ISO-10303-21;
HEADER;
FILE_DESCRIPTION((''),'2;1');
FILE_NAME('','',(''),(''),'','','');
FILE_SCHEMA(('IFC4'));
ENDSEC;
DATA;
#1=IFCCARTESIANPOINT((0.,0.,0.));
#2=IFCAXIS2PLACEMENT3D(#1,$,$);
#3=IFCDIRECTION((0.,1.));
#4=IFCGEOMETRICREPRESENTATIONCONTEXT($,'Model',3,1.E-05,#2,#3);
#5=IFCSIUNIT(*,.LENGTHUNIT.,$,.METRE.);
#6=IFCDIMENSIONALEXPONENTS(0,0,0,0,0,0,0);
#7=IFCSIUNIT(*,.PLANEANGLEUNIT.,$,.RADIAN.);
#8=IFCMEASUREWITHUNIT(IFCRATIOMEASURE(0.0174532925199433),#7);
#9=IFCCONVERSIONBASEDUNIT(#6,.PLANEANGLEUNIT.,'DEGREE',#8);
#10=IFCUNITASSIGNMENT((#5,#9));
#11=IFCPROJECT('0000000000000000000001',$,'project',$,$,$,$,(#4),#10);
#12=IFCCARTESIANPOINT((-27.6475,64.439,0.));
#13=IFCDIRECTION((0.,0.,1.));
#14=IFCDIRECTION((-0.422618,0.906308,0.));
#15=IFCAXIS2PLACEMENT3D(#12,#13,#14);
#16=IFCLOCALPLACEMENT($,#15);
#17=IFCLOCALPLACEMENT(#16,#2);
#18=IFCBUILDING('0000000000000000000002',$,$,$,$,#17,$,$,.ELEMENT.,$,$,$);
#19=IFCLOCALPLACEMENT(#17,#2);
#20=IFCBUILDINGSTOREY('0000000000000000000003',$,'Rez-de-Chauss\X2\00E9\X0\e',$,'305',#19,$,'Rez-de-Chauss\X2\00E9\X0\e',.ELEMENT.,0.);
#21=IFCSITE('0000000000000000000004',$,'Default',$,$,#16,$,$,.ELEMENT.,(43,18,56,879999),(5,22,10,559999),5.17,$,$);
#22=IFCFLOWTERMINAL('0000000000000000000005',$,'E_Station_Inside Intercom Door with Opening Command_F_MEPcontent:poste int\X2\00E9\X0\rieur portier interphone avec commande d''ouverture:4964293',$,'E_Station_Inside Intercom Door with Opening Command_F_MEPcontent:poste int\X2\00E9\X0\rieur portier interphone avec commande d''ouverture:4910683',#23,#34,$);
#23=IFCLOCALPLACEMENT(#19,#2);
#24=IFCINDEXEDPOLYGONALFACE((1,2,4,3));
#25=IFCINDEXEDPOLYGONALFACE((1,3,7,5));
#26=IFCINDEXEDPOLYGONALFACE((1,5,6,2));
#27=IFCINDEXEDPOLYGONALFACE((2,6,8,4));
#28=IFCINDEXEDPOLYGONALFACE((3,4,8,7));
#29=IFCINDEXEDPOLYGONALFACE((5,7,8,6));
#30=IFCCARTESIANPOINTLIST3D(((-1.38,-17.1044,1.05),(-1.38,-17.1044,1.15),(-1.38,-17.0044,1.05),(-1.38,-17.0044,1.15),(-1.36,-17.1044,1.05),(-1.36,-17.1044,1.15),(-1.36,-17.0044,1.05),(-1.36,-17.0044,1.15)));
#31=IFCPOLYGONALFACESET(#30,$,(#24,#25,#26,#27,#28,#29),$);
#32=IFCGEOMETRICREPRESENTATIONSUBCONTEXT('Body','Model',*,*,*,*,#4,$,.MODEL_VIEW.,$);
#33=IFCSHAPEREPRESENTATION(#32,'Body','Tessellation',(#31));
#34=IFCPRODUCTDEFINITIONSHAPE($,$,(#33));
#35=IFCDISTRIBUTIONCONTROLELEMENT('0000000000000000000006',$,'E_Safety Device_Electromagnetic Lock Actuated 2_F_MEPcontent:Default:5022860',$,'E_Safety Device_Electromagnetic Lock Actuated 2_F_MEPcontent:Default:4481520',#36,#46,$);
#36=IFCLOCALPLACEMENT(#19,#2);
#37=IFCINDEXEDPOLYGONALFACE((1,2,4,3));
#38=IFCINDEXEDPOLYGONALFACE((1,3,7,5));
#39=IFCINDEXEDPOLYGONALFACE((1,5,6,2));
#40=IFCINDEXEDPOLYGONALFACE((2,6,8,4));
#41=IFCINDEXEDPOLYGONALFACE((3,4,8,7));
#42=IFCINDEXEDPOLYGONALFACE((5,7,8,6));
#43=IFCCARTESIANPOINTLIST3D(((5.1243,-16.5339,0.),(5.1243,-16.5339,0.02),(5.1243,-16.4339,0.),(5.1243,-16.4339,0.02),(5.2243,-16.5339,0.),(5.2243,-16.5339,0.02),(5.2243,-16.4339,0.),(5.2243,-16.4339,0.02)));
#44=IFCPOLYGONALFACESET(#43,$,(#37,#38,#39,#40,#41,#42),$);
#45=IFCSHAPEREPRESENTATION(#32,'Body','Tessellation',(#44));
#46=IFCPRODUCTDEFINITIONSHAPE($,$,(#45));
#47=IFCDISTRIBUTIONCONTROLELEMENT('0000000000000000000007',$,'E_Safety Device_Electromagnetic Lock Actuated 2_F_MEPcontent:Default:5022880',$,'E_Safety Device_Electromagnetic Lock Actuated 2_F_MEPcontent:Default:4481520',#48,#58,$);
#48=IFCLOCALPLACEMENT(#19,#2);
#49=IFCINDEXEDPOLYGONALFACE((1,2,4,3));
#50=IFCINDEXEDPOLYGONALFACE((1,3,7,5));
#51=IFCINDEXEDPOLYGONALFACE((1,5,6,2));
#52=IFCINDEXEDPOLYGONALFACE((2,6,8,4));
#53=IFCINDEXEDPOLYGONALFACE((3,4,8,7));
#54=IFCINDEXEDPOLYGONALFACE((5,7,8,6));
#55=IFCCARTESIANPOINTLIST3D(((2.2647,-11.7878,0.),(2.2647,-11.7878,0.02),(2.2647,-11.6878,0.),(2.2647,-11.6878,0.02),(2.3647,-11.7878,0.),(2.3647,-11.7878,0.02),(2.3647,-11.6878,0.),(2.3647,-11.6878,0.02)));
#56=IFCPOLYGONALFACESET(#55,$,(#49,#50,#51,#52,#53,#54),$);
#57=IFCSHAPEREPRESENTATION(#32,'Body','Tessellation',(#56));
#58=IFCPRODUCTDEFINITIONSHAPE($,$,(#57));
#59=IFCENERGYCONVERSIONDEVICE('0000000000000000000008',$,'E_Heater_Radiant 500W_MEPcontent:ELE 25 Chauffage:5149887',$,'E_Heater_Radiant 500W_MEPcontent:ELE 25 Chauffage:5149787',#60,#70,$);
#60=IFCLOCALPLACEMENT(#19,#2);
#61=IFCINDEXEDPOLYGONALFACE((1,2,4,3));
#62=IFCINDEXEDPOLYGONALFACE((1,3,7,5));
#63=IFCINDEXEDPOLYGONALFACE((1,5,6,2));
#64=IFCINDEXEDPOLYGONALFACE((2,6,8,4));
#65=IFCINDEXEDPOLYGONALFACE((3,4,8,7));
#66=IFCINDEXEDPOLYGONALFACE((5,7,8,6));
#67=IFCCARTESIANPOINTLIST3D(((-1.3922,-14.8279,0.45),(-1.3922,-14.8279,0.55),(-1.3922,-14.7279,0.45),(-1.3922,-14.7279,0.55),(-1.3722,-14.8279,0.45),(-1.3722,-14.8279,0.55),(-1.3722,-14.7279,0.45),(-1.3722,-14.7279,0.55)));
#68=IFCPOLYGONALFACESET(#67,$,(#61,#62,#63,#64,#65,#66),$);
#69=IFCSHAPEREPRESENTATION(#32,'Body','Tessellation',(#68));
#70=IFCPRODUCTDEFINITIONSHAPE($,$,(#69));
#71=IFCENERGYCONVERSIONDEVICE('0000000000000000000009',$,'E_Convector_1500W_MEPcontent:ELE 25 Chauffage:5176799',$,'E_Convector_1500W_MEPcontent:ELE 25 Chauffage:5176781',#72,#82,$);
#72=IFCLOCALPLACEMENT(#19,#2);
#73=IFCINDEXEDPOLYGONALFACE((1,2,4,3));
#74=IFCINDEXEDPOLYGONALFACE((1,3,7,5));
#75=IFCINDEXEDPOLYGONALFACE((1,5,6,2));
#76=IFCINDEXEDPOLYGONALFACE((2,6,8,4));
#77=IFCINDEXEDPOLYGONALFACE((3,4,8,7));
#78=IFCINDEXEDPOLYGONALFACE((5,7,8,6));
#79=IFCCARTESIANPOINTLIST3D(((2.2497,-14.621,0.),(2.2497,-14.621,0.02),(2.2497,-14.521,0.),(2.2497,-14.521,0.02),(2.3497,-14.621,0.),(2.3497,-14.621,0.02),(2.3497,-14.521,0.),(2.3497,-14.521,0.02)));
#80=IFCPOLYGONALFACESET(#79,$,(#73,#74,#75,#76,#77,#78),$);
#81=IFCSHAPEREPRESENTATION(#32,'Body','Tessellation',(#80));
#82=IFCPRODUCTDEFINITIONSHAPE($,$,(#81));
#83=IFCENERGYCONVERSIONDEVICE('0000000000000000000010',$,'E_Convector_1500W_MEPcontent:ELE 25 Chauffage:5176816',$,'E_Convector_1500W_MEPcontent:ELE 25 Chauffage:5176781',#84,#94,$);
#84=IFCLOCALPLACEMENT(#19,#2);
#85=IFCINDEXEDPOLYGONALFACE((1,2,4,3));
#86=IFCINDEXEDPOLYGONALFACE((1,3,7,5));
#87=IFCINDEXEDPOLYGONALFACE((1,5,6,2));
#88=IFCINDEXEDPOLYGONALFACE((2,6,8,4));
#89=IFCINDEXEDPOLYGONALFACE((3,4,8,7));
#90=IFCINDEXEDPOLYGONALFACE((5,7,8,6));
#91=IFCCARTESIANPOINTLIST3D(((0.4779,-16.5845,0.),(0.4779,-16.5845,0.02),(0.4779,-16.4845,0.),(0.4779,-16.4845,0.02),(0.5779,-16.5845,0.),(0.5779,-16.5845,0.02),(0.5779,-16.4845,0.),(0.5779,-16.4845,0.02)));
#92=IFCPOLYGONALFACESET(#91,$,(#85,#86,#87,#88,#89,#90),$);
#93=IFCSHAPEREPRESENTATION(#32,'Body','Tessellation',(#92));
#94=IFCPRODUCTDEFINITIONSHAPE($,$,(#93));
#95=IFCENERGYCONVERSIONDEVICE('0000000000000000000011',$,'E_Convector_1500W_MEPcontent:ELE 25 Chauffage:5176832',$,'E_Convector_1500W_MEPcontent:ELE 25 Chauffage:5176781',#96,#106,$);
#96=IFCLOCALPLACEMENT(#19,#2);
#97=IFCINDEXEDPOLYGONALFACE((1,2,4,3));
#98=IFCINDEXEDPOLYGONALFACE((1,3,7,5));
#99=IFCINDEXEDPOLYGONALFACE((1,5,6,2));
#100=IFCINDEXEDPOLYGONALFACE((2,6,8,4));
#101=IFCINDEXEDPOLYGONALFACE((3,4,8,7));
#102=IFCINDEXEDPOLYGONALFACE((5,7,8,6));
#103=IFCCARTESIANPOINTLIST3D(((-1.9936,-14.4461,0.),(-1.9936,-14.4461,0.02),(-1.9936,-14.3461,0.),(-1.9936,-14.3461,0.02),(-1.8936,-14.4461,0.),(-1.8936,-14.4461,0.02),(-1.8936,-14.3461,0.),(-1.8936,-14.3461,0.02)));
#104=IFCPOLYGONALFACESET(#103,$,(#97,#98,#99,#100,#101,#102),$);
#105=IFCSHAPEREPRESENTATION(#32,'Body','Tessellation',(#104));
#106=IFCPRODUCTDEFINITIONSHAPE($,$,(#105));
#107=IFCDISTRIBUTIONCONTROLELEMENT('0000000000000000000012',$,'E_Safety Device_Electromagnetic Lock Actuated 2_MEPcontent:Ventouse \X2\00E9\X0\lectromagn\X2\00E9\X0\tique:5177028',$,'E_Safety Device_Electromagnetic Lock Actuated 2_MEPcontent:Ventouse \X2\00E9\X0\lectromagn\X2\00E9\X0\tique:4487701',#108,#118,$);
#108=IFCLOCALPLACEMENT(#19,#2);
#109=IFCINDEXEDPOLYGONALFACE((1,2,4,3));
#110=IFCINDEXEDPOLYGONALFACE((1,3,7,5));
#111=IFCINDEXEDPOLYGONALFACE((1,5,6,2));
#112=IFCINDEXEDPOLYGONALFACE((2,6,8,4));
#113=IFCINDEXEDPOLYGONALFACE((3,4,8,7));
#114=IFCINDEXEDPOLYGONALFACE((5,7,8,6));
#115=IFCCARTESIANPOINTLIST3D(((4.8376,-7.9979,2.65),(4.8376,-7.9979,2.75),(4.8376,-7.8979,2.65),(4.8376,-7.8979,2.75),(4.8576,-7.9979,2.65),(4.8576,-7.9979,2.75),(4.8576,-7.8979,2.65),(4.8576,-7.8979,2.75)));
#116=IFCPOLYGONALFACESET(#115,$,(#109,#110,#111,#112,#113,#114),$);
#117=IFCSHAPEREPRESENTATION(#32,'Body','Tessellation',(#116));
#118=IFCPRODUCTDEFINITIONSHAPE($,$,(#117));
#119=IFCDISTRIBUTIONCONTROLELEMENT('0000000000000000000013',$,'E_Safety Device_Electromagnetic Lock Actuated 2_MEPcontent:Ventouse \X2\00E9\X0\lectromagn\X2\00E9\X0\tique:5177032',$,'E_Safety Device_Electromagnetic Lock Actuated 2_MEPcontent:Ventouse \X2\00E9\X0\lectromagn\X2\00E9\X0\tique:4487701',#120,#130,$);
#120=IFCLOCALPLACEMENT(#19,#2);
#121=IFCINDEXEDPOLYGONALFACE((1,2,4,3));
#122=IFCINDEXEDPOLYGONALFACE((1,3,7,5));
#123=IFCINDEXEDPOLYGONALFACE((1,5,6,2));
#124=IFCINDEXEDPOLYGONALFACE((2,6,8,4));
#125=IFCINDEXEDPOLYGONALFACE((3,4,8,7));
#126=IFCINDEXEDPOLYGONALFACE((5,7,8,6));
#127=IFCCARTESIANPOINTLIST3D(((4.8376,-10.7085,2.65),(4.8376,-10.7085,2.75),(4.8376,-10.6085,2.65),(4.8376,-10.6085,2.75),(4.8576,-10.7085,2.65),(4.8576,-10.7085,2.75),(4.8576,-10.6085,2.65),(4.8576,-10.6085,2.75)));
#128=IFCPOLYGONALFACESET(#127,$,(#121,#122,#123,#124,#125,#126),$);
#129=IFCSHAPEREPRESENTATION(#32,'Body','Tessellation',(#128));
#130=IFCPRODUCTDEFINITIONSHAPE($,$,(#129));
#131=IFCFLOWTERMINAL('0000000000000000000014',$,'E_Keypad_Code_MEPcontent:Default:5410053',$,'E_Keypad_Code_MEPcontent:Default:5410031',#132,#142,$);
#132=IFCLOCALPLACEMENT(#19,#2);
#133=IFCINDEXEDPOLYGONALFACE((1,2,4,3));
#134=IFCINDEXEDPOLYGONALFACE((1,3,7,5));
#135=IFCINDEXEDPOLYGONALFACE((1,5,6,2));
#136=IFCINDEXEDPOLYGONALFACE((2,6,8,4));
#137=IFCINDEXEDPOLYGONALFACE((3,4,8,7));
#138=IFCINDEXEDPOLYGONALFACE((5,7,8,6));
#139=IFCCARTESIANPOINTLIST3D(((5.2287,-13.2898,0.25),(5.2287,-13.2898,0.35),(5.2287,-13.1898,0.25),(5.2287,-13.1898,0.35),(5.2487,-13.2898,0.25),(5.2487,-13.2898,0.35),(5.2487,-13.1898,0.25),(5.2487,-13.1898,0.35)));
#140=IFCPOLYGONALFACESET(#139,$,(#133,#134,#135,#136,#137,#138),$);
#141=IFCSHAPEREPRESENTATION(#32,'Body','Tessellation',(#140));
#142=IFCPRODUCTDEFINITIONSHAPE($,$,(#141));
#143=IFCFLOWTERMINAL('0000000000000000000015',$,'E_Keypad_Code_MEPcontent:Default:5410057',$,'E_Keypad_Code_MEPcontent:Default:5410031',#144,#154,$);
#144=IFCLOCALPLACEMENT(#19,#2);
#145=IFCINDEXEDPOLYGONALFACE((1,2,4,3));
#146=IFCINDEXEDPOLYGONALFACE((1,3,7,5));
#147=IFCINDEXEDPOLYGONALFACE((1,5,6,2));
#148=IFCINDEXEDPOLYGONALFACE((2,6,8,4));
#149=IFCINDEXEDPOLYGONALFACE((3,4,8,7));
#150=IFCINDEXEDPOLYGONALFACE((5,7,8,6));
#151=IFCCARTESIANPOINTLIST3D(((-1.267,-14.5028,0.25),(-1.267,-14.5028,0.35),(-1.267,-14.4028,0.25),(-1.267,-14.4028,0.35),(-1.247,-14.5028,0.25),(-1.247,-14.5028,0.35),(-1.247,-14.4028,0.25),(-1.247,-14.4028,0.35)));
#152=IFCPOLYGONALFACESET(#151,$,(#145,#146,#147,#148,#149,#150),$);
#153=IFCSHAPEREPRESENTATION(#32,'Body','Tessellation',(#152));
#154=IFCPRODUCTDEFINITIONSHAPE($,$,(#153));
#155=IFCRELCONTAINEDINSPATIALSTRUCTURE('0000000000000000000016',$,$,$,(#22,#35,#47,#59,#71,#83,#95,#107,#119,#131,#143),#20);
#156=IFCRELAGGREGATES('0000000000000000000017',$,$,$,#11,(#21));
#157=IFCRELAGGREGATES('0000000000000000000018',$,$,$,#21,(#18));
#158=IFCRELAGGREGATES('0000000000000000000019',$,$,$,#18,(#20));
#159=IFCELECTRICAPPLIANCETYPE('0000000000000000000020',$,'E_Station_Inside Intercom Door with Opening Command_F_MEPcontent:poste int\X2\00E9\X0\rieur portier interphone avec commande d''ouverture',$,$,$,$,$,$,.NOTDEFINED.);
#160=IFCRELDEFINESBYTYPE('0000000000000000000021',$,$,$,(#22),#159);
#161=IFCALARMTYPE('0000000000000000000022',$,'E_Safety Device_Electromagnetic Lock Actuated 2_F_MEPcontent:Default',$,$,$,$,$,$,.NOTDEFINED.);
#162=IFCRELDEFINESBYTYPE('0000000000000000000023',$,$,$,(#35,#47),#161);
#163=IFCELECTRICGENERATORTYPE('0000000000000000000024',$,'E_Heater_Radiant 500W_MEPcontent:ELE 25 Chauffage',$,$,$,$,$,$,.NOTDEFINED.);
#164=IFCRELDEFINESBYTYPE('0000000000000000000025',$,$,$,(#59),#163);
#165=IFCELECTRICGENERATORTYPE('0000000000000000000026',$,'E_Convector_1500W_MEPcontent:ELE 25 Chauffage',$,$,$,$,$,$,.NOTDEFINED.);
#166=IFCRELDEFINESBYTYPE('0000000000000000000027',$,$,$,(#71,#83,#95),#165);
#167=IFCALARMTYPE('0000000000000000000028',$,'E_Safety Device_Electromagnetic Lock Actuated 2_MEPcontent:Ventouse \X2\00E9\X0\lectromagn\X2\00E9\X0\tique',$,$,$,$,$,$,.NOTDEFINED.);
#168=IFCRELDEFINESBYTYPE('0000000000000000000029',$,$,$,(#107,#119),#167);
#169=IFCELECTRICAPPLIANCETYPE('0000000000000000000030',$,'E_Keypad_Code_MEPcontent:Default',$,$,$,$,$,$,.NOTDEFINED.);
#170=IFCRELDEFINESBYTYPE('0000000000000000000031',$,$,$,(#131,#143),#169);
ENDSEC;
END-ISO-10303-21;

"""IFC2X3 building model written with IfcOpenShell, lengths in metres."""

from ifc_helpers import new_model, entity, si_unit, converted_unit, direction, frame, frame_2d, origin, origin_2d_with_axis, place, context, subcontext, project, spatial, rectangle, extrude, source, transform, mapped, type_object, type_shapes, element, save


model = new_model("IFC2X3")

# Units and contexts
model_context = context("Model", 3, precision=1e-05, world=origin(), true_north=direction((0.0, 1.0)))
body_context = subcontext(model_context, "Body", "Model", "MODEL_VIEW")
ifc_project = project(units=[si_unit("LENGTHUNIT", "METRE"), converted_unit("PLANEANGLEUNIT", "DEGREE", entity("IfcRatioMeasure", 0.0174532925199433), si_unit("PLANEANGLEUNIT", "RADIAN"), dimensions=[0, 0, 0, 0, 0, 0, 0])], contexts=[model_context])

# Site, building, storey
site_placement = place(None, frame((-27.6475, 64.439, 0.0), z_axis=(0.0, 0.0, 1.0), x_axis=(-0.422618, 0.906308, 0.0)))
site = spatial("IfcSite", under=ifc_project, at=site_placement, Name="Default", CompositionType="ELEMENT", RefLatitude=(43, 18, 56, 879999), RefLongitude=(5, 22, 10, 559999), RefElevation=5.17)
building_placement = place(site_placement, origin())
building = spatial("IfcBuilding", under=site, at=building_placement, CompositionType="ELEMENT")
storey_placement = place(building_placement, origin())
storey = spatial("IfcBuildingStorey", under=building, at=storey_placement, Name="Rez-de-Chaussée", ObjectType="305", LongName="Rez-de-Chaussée", CompositionType="ELEMENT", Elevation=0.0)

# Flow terminal
electric_appliance_type_1 = type_object("IfcElectricApplianceType", Name="E_Station_Inside Intercom Door with Opening Command_F_MEPcontent:poste intérieur portier interphone avec commande d'ouverture", PredefinedType="NOTDEFINED")
shared_shape_1 = source(origin(), body_context, "Body", "SweptSolid", [
    extrude(rectangle(XDim=0.1, YDim=0.1, at=origin_2d_with_axis()), frame((0.0, 0.0, 0.0), z_axis=(0.0, 0.0, 1.0), x_axis=(0.0, 1.0, 0.0)), (0.0, 0.0, 1.0), 0.02),
])
type_shapes(electric_appliance_type_1, [shared_shape_1])
flow_terminal_1_placement = place(storey_placement, frame((-1.36, -17.0544, 1.1), z_axis=(-1.0, 0.0, 0.0), x_axis=(0.0, -1.0, 0.0)))
element("IfcFlowTerminal", 1, at=flow_terminal_1_placement, inside=storey, type_object=electric_appliance_type_1, Name="E_Station_Inside Intercom Door with Opening Command_F_MEPcontent:poste intérieur portier interphone avec commande d'ouverture:4964293", ObjectType="E_Station_Inside Intercom Door with Opening Command_F_MEPcontent:poste intérieur portier interphone avec commande d'ouverture:4910683", context=body_context, shape_type="MappedRepresentation", body=[
    mapped(shared_shape_1, transform((0.0, 0.0, 0.0), scale=1.0)),
])

# Distribution control elements
alarm_type_1 = type_object("IfcAlarmType", Name="E_Safety Device_Electromagnetic Lock Actuated 2_F_MEPcontent:Default", PredefinedType="NOTDEFINED")
shared_shape_2 = source(origin(), body_context, "Body", "SweptSolid", [
    extrude(rectangle(XDim=0.1, YDim=0.1, at=origin_2d_with_axis()), frame((0.0, 0.0, 0.0), z_axis=(0.0, 0.0, 1.0), x_axis=(0.0, 1.0, 0.0)), (0.0, 0.0, 1.0), 0.02),
])
type_shapes(alarm_type_1, [shared_shape_2])
for number, where, z_axis, x_axis, name in (
    (2, (5.1743, -16.4839, 0.0), (0.0, 0.0, 1.0), (-1.0, 0.0, 0.0), "E_Safety Device_Electromagnetic Lock Actuated 2_F_MEPcontent:Default:5022860"),
    (3, (2.3147, -11.7378, 0.0), (0.0, 0.0, 1.0), (0.0, -1.0, 0.0), "E_Safety Device_Electromagnetic Lock Actuated 2_F_MEPcontent:Default:5022880"),
):
    element("IfcDistributionControlElement", number, at=place(storey_placement, frame(where, z_axis=z_axis, x_axis=x_axis)), inside=storey, type_object=alarm_type_1, Name=name, ObjectType="E_Safety Device_Electromagnetic Lock Actuated 2_F_MEPcontent:Default:4481520", context=body_context, shape_type="MappedRepresentation", body=[
        mapped(shared_shape_2, transform((0.0, 0.0, 0.0), scale=1.0)),
    ])

# Energy conversion devices
electric_generator_type_1 = type_object("IfcElectricGeneratorType", Name="E_Heater_Radiant 500W_MEPcontent:ELE 25 Chauffage", PredefinedType="NOTDEFINED")
shared_shape_3 = source(origin(), body_context, "Body", "SweptSolid", [
    extrude(rectangle(XDim=0.02, YDim=0.1, at=frame_2d((0.0, 0.0), x_axis=(1.0, 0.0))), frame((0.0, 0.01, -0.05), z_axis=(0.0, 0.0, 1.0), x_axis=(0.0, -1.0, 0.0)), (0.0, 0.0, 1.0), 0.1),
])
type_shapes(electric_generator_type_1, [shared_shape_3])
energy_conversion_device_1_placement = place(storey_placement, frame((-1.3722, -14.7779, 0.5), z_axis=(0.0, 0.0, 1.0), x_axis=(0.0, 1.0, 0.0)))
element("IfcEnergyConversionDevice", 4, at=energy_conversion_device_1_placement, inside=storey, type_object=electric_generator_type_1, Name="E_Heater_Radiant 500W_MEPcontent:ELE 25 Chauffage:5149887", ObjectType="E_Heater_Radiant 500W_MEPcontent:ELE 25 Chauffage:5149787", context=body_context, shape_type="MappedRepresentation", body=[
    mapped(shared_shape_3, transform((0.0, 0.0, 0.0), scale=1.0)),
])
electric_generator_type_2 = type_object("IfcElectricGeneratorType", Name="E_Convector_1500W_MEPcontent:ELE 25 Chauffage", PredefinedType="NOTDEFINED")
shared_shape_4 = source(origin(), body_context, "Body", "SweptSolid", [
    extrude(rectangle(XDim=0.1, YDim=0.1, at=origin_2d_with_axis()), frame((0.0, 0.0, 0.0), z_axis=(0.0, 0.0, 1.0), x_axis=(0.0, -1.0, 0.0)), (0.0, 0.0, 1.0), 0.02),
])
type_shapes(electric_generator_type_2, [shared_shape_4])
energy_conversion_device_2_placement = place(storey_placement, frame((2.2997, -14.571, 0.0), z_axis=(0.0, 0.0, 1.0), x_axis=(0.0, -1.0, 0.0)))
element("IfcEnergyConversionDevice", 5, at=energy_conversion_device_2_placement, inside=storey, type_object=electric_generator_type_2, Name="E_Convector_1500W_MEPcontent:ELE 25 Chauffage:5176799", ObjectType="E_Convector_1500W_MEPcontent:ELE 25 Chauffage:5176781", context=body_context, shape_type="MappedRepresentation", body=[
    mapped(shared_shape_4, transform((0.0, 0.0, 0.0), scale=1.0)),
])
for number, where, name in (
    (6, (0.5279, -16.5345, 0.0), "E_Convector_1500W_MEPcontent:ELE 25 Chauffage:5176816"),
    (7, (-1.9436, -14.3961, 0.0), "E_Convector_1500W_MEPcontent:ELE 25 Chauffage:5176832"),
):
    element("IfcEnergyConversionDevice", number, at=place(storey_placement, frame(where)), inside=storey, type_object=electric_generator_type_2, Name=name, ObjectType="E_Convector_1500W_MEPcontent:ELE 25 Chauffage:5176781", context=body_context, shape_type="MappedRepresentation", body=[
        mapped(shared_shape_4, transform((0.0, 0.0, 0.0), scale=1.0)),
    ])

# Distribution control elements
alarm_type_2 = type_object("IfcAlarmType", Name="E_Safety Device_Electromagnetic Lock Actuated 2_MEPcontent:Ventouse électromagnétique", PredefinedType="NOTDEFINED")
shared_shape_5 = source(origin(), body_context, "Body", "SweptSolid", [
    extrude(rectangle(XDim=0.02, YDim=0.1, at=frame_2d((0.0, 0.0), x_axis=(1.0, 0.0))), frame((0.0, 0.01, -0.05), z_axis=(0.0, 0.0, 1.0), x_axis=(0.0, -1.0, 0.0)), (0.0, 0.0, 1.0), 0.1),
])
type_shapes(alarm_type_2, [shared_shape_5])
for number, where, z_axis, x_axis, name in (
    (8, (4.8576, -7.9479, 2.7), (0.0, 0.0, 1.0), (0.0, 1.0, 0.0), "E_Safety Device_Electromagnetic Lock Actuated 2_MEPcontent:Ventouse électromagnétique:5177028"),
    (9, (4.8576, -10.6585, 2.7), (0.0, 0.0, 1.0), (0.0, 1.0, 0.0), "E_Safety Device_Electromagnetic Lock Actuated 2_MEPcontent:Ventouse électromagnétique:5177032"),
):
    element("IfcDistributionControlElement", number, at=place(storey_placement, frame(where, z_axis=z_axis, x_axis=x_axis)), inside=storey, type_object=alarm_type_2, Name=name, ObjectType="E_Safety Device_Electromagnetic Lock Actuated 2_MEPcontent:Ventouse électromagnétique:4487701", context=body_context, shape_type="MappedRepresentation", body=[
        mapped(shared_shape_5, transform((0.0, 0.0, 0.0), scale=1.0)),
    ])

# Flow terminals
electric_appliance_type_2 = type_object("IfcElectricApplianceType", Name="E_Keypad_Code_MEPcontent:Default", PredefinedType="NOTDEFINED")
shared_shape_6 = source(origin(), body_context, "Body", "SweptSolid", [
    extrude(rectangle(XDim=0.02, YDim=0.1, at=frame_2d((0.0, 0.0), x_axis=(1.0, 0.0))), frame((0.0, 0.01, -0.05), z_axis=(0.0, 0.0, 1.0), x_axis=(0.0, -1.0, 0.0)), (0.0, 0.0, 1.0), 0.1),
])
type_shapes(electric_appliance_type_2, [shared_shape_6])
for number, where, z_axis, x_axis, name in (
    (10, (5.2287, -13.2398, 0.3), (0.0, 0.0, 1.0), (0.0, -1.0, 0.0), "E_Keypad_Code_MEPcontent:Default:5410053"),
    (11, (-1.267, -14.4528, 0.3), (0.0, 0.0, 1.0), (0.0, -1.0, 0.0), "E_Keypad_Code_MEPcontent:Default:5410057"),
):
    element("IfcFlowTerminal", number, at=place(storey_placement, frame(where, z_axis=z_axis, x_axis=x_axis)), inside=storey, type_object=electric_appliance_type_2, Name=name, ObjectType="E_Keypad_Code_MEPcontent:Default:5410031", context=body_context, shape_type="MappedRepresentation", body=[
        mapped(shared_shape_6, transform((0.0, 0.0, 0.0), scale=1.0)),
    ])

save(model, "model.ifc")
